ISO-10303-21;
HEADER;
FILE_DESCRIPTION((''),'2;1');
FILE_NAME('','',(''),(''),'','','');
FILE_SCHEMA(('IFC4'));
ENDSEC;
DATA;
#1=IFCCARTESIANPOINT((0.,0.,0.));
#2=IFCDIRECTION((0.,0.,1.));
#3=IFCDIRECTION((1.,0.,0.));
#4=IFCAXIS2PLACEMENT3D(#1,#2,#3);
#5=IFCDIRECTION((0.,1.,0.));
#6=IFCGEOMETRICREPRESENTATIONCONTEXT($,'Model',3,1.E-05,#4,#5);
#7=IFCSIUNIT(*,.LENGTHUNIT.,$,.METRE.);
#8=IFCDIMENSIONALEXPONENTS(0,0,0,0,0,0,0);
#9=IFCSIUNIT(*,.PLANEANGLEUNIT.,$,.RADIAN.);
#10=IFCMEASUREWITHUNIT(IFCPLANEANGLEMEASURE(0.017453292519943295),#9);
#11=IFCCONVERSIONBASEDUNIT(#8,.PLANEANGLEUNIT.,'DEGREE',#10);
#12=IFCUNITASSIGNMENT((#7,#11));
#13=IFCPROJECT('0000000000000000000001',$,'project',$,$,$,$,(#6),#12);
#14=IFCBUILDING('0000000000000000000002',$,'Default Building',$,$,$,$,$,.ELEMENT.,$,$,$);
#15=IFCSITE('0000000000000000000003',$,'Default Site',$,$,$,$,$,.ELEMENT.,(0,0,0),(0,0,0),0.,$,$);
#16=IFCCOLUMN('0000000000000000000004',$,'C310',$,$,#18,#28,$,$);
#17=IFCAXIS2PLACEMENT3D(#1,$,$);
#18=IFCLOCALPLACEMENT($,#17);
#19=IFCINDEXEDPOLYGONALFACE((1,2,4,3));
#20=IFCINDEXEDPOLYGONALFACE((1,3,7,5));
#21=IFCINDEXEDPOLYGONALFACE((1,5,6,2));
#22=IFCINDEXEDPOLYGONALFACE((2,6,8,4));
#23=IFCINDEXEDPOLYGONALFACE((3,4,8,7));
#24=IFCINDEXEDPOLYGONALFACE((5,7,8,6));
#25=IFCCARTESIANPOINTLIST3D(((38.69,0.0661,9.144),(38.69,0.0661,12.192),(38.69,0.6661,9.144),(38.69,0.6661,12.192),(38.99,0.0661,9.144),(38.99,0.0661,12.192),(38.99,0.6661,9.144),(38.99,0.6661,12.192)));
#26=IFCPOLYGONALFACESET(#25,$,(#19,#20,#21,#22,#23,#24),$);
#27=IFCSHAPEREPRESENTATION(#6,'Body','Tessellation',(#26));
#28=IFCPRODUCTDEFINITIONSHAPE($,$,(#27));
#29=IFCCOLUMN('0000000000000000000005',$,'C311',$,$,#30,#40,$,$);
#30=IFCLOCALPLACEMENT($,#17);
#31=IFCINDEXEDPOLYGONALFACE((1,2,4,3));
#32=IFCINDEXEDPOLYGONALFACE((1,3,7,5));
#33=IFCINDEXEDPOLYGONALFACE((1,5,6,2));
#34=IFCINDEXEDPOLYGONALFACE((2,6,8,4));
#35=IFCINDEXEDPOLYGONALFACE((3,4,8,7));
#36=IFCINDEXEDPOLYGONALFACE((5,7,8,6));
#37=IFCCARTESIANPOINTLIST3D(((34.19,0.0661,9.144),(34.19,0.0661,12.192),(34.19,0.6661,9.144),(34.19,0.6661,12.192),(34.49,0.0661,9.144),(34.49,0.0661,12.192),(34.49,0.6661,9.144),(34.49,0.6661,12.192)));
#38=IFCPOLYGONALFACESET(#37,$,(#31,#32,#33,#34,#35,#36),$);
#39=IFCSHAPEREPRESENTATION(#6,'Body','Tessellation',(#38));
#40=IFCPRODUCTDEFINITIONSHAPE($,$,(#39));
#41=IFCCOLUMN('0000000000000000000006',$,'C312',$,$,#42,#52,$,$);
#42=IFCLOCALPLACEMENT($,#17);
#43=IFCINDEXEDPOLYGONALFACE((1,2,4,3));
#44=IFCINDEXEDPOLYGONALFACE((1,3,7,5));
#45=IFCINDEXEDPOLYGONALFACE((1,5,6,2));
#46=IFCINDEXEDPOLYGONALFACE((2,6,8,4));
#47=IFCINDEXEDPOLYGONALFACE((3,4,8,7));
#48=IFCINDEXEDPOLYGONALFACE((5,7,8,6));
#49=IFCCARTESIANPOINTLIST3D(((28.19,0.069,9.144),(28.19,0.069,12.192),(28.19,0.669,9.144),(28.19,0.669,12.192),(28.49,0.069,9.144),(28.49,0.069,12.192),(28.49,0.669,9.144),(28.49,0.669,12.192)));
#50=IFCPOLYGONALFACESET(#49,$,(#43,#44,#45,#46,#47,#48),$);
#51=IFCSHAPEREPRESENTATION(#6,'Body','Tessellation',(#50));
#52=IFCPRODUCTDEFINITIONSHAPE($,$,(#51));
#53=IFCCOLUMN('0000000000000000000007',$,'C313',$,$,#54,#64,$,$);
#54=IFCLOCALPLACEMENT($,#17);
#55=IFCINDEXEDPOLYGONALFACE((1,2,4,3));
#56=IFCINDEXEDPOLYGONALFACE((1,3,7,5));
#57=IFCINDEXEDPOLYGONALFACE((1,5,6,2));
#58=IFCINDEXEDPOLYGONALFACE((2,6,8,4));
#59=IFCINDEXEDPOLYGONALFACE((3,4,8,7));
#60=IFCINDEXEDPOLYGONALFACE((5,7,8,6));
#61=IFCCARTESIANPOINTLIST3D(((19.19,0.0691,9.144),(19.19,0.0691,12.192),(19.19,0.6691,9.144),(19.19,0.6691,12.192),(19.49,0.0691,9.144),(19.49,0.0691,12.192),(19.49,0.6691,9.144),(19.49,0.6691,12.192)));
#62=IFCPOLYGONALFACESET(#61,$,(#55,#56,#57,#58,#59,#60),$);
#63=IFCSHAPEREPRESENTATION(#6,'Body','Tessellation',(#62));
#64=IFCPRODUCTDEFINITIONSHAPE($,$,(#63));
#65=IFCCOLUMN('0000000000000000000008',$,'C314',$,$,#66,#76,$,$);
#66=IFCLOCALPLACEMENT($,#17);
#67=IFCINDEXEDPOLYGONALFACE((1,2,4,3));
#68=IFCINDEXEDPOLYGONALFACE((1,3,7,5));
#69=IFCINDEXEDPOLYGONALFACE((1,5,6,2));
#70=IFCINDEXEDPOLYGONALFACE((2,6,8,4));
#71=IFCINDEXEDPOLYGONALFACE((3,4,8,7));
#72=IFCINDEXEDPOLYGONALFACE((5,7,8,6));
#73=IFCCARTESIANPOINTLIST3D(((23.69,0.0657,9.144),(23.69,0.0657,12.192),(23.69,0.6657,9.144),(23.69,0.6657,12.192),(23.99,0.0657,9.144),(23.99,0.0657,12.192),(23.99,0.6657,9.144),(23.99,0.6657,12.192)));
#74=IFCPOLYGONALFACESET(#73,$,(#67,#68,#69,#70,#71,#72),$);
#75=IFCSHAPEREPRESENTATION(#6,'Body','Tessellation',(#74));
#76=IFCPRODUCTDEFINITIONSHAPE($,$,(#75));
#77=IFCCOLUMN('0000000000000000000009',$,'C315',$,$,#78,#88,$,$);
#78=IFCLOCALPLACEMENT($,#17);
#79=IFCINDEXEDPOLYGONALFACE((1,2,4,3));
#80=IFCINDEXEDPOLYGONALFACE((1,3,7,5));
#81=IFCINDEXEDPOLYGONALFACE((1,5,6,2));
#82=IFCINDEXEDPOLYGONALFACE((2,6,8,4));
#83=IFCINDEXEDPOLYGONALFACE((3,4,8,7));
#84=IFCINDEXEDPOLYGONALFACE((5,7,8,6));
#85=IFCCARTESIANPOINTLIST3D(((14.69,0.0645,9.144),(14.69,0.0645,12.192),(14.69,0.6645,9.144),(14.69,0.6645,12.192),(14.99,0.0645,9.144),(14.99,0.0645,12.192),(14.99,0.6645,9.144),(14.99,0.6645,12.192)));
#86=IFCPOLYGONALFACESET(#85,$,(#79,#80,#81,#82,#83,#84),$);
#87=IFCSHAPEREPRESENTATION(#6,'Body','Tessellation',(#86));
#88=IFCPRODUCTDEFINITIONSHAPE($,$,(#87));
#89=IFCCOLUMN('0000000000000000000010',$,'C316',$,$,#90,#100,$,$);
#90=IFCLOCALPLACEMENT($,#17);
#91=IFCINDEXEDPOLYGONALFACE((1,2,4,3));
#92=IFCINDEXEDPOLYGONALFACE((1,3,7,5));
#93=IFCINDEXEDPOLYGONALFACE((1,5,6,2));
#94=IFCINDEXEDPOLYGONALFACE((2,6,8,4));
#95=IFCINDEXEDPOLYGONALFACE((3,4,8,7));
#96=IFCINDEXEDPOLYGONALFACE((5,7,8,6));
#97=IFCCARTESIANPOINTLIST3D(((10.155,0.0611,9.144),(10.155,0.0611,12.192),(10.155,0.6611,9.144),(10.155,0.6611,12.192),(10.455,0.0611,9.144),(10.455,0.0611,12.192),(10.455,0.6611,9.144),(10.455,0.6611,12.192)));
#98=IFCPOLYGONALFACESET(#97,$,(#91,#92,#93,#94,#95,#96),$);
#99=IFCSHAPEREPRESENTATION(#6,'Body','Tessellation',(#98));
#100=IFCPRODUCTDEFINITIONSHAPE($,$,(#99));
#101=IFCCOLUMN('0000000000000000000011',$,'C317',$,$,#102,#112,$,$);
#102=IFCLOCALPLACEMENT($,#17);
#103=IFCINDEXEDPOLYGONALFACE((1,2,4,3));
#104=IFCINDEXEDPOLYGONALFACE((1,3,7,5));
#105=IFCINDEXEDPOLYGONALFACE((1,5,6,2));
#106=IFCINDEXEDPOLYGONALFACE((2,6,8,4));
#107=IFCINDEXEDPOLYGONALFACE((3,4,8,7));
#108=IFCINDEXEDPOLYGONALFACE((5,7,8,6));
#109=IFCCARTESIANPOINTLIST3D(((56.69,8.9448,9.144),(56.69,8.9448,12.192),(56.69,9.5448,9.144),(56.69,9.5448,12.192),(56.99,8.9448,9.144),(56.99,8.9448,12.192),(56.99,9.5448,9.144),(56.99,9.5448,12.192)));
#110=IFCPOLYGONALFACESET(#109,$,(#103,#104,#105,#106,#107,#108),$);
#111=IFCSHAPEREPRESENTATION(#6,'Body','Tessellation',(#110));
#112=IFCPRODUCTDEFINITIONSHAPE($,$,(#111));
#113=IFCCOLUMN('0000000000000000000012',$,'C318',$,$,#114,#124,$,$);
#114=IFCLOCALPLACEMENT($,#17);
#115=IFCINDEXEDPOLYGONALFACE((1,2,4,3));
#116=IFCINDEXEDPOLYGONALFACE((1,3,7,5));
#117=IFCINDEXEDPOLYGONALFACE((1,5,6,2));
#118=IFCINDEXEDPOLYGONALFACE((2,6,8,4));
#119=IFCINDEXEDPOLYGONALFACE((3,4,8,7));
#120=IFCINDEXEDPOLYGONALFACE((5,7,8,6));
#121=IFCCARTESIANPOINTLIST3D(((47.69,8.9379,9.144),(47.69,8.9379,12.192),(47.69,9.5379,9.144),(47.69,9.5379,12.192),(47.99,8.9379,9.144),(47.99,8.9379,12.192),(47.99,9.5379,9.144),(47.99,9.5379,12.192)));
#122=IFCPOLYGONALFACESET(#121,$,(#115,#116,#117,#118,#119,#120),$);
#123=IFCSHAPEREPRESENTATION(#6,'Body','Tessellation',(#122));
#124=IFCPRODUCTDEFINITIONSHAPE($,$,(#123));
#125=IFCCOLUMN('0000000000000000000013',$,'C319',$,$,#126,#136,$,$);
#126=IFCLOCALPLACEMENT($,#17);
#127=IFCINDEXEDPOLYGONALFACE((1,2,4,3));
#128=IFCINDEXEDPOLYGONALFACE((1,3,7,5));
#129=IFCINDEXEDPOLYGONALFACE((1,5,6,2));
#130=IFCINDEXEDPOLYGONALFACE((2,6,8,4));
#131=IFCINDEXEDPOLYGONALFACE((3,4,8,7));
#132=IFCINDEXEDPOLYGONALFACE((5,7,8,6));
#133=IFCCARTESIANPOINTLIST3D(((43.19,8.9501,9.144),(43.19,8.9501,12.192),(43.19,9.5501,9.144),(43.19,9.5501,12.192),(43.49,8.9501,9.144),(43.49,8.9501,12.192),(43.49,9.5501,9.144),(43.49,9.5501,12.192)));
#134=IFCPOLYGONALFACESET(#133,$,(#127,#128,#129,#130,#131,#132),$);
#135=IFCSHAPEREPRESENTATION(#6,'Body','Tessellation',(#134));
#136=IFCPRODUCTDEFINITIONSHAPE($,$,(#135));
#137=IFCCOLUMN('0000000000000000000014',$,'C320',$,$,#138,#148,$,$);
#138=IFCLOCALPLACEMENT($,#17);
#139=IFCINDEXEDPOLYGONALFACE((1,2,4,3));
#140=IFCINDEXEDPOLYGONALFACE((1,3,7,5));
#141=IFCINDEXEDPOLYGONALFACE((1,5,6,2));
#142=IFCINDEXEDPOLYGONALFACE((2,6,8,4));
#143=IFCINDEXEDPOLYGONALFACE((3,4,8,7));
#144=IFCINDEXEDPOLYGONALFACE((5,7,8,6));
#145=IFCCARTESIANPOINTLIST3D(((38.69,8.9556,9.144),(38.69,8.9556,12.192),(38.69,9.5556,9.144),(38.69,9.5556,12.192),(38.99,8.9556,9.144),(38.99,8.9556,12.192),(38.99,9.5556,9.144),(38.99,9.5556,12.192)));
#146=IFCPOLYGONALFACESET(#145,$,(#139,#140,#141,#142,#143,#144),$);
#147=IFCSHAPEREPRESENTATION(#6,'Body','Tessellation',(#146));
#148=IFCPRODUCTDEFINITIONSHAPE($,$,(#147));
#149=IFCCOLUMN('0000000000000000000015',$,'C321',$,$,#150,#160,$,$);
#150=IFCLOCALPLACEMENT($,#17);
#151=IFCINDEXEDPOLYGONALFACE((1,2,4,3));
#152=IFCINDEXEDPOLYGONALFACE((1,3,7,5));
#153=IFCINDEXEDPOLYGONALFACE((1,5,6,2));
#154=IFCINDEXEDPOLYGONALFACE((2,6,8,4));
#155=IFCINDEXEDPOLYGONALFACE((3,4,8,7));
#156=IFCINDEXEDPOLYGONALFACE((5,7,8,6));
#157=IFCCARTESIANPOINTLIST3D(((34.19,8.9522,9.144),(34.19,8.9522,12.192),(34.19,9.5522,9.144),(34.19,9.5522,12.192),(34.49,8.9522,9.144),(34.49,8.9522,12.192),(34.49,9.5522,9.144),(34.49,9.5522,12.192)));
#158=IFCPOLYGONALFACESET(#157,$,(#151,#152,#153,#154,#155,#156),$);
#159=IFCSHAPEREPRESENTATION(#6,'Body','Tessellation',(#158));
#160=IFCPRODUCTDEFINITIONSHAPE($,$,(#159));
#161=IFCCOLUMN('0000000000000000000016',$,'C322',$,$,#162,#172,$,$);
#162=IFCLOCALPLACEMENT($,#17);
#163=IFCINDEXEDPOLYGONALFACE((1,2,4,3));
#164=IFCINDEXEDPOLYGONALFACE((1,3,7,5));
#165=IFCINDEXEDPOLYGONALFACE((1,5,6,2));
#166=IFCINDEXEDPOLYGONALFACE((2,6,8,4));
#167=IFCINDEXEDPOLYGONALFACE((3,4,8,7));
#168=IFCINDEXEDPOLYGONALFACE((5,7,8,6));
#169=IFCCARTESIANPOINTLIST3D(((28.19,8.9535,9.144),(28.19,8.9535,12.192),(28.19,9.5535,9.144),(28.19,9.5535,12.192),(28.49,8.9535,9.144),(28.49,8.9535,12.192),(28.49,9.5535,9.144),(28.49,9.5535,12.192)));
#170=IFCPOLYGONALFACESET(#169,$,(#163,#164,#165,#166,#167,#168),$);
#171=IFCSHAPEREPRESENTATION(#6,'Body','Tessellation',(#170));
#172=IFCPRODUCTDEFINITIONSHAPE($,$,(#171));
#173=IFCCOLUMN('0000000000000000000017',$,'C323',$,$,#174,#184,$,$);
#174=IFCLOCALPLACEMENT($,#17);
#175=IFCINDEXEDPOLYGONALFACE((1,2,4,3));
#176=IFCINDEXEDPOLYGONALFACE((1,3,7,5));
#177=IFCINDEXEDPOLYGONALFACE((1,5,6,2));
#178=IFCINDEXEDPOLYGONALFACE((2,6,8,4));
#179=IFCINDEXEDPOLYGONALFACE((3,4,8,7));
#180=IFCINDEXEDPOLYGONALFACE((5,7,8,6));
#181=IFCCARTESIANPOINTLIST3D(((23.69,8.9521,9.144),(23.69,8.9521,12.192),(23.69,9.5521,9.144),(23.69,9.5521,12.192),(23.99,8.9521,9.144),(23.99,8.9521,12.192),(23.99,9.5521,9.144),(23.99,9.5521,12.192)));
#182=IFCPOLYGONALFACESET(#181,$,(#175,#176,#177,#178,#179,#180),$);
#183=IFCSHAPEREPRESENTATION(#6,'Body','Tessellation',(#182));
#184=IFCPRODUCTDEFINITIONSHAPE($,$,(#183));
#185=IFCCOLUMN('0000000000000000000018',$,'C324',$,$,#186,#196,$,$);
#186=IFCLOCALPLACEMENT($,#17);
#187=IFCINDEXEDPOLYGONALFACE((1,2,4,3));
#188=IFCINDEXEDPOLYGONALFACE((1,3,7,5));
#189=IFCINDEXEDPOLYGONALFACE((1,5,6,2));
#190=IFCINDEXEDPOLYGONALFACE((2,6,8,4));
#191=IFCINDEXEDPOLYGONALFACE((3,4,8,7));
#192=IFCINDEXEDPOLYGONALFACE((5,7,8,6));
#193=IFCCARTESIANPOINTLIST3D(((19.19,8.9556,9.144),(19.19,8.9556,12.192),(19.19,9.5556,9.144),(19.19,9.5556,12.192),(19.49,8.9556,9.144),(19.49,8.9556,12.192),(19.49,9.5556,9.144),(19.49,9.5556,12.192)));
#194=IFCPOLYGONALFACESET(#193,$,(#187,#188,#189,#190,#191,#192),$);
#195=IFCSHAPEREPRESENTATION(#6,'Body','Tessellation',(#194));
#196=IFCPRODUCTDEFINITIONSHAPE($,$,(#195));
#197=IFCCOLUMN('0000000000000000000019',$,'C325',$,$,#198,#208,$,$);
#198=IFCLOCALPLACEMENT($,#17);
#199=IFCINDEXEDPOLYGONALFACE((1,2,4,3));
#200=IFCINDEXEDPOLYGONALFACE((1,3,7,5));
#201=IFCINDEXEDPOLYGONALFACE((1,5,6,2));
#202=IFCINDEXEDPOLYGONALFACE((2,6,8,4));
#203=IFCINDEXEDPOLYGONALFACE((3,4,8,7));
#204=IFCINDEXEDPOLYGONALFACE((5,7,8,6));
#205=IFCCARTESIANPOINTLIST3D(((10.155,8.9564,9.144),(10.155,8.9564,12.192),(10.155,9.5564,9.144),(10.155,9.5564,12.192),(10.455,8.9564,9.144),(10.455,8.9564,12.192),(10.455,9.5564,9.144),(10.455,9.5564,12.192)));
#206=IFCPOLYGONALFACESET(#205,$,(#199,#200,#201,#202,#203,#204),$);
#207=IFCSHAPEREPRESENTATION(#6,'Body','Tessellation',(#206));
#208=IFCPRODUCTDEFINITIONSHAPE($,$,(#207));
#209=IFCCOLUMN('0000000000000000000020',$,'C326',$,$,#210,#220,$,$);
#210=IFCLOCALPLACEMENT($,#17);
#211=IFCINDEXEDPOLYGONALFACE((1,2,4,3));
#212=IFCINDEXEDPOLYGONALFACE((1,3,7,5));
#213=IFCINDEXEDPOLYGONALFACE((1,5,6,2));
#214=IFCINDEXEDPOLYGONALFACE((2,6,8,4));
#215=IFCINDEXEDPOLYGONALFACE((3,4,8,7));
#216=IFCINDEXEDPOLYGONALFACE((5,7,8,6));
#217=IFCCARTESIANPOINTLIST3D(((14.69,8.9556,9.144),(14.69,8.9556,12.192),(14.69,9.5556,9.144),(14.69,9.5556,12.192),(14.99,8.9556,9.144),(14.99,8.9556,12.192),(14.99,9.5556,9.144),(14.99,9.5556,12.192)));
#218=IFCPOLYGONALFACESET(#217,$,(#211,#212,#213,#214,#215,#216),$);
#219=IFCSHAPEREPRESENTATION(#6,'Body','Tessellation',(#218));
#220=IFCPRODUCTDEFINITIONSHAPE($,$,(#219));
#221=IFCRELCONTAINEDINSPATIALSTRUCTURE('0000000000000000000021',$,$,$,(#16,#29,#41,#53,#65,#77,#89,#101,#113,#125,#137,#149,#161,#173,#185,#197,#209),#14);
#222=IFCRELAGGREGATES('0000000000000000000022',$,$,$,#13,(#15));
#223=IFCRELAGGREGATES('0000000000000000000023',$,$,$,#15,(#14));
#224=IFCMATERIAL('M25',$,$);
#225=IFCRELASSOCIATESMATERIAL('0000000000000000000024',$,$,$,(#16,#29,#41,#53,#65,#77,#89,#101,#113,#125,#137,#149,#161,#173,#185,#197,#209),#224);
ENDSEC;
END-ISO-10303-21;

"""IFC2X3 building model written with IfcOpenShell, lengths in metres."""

from ifc_helpers import new_model, entity, si_unit, converted_unit, direction, frame, frame_2d, origin_with_axes, place, context, project, spatial, rectangle, extrude, material, element, save


model = new_model("IFC2X3")

# Units and contexts
model_context = context("Model", 3, precision=1e-05, world=origin_with_axes(), true_north=direction((0.0, 1.0, 0.0)))
ifc_project = project(units=[si_unit("LENGTHUNIT", "METRE"), converted_unit("PLANEANGLEUNIT", "DEGREE", entity("IfcPlaneAngleMeasure", 0.017453292519943295), si_unit("PLANEANGLEUNIT", "RADIAN"), dimensions=[0, 0, 0, 0, 0, 0, 0])], contexts=[model_context])

# Site, building
site = spatial("IfcSite", under=ifc_project, Name="Default Site", CompositionType="ELEMENT", RefLatitude=(0, 0, 0), RefLongitude=(0, 0, 0), RefElevation=0.0)
building = spatial("IfcBuilding", under=site, Name="Default Building", CompositionType="ELEMENT")

# Columns
ifc_material = material(Name="M25")
placement = place(None, origin_with_axes())
element("IfcColumn", 1, at=placement, inside=building, material=ifc_material, Name="C310", context=model_context, shape_type="SweptSolid", body=[
    extrude(rectangle(XDim=0.3, YDim=0.6, at=frame_2d((0.0, 0.0), x_axis=(1.0, 0.0, 0.0))), frame((38.84, 0.3661, 9.144), z_axis=(0.0, 0.0, 1.0), x_axis=(1.0, 0.0, 0.0)), (0.0, 0.0, 1.0), 3.048),
])
element("IfcColumn", 2, at=placement, inside=building, material=ifc_material, Name="C311", context=model_context, shape_type="SweptSolid", body=[
    extrude(rectangle(XDim=0.3, YDim=0.6, at=frame_2d((0.0, 0.0), x_axis=(1.0, 0.0, 0.0))), frame((34.34, 0.3661, 9.144), z_axis=(0.0, 0.0, 1.0), x_axis=(1.0, 0.0, 0.0)), (0.0, 0.0, 1.0), 3.048),
])
element("IfcColumn", 3, at=placement, inside=building, material=ifc_material, Name="C312", context=model_context, shape_type="SweptSolid", body=[
    extrude(rectangle(XDim=0.3, YDim=0.6, at=frame_2d((0.0, 0.0), x_axis=(1.0, 0.0, 0.0))), frame((28.34, 0.369, 9.144), z_axis=(0.0, 0.0, 1.0), x_axis=(1.0, 0.0, 0.0)), (0.0, 0.0, 1.0), 3.048),
])
element("IfcColumn", 4, at=placement, inside=building, material=ifc_material, Name="C313", context=model_context, shape_type="SweptSolid", body=[
    extrude(rectangle(XDim=0.3, YDim=0.6, at=frame_2d((0.0, 0.0), x_axis=(1.0, 0.0, 0.0))), frame((19.34, 0.3691, 9.144), z_axis=(0.0, 0.0, 1.0), x_axis=(1.0, 0.0, 0.0)), (0.0, 0.0, 1.0), 3.048),
])
element("IfcColumn", 5, at=placement, inside=building, material=ifc_material, Name="C314", context=model_context, shape_type="SweptSolid", body=[
    extrude(rectangle(XDim=0.3, YDim=0.6, at=frame_2d((0.0, 0.0), x_axis=(1.0, 0.0, 0.0))), frame((23.84, 0.3657, 9.144), z_axis=(0.0, 0.0, 1.0), x_axis=(1.0, 0.0, 0.0)), (0.0, 0.0, 1.0), 3.048),
])
element("IfcColumn", 6, at=placement, inside=building, material=ifc_material, Name="C315", context=model_context, shape_type="SweptSolid", body=[
    extrude(rectangle(XDim=0.3, YDim=0.6, at=frame_2d((0.0, 0.0), x_axis=(1.0, 0.0, 0.0))), frame((14.84, 0.3645, 9.144), z_axis=(0.0, 0.0, 1.0), x_axis=(1.0, 0.0, 0.0)), (0.0, 0.0, 1.0), 3.048),
])
element("IfcColumn", 7, at=placement, inside=building, material=ifc_material, Name="C316", context=model_context, shape_type="SweptSolid", body=[
    extrude(rectangle(XDim=0.3, YDim=0.6, at=frame_2d((0.0, 0.0), x_axis=(1.0, 0.0, 0.0))), frame((10.305, 0.3611, 9.144), z_axis=(0.0, 0.0, 1.0), x_axis=(1.0, 0.0, 0.0)), (0.0, 0.0, 1.0), 3.048),
])
element("IfcColumn", 8, at=placement, inside=building, material=ifc_material, Name="C317", context=model_context, shape_type="SweptSolid", body=[
    extrude(rectangle(XDim=0.3, YDim=0.6, at=frame_2d((0.0, 0.0), x_axis=(1.0, 0.0, 0.0))), frame((56.84, 9.2448, 9.144), z_axis=(0.0, 0.0, 1.0), x_axis=(1.0, 0.0, 0.0)), (0.0, 0.0, 1.0), 3.048),
])
element("IfcColumn", 9, at=placement, inside=building, material=ifc_material, Name="C318", context=model_context, shape_type="SweptSolid", body=[
    extrude(rectangle(XDim=0.3, YDim=0.6, at=frame_2d((0.0, 0.0), x_axis=(1.0, 0.0, 0.0))), frame((47.84, 9.2379, 9.144), z_axis=(0.0, 0.0, 1.0), x_axis=(1.0, 0.0, 0.0)), (0.0, 0.0, 1.0), 3.048),
])
element("IfcColumn", 10, at=placement, inside=building, material=ifc_material, Name="C319", context=model_context, shape_type="SweptSolid", body=[
    extrude(rectangle(XDim=0.3, YDim=0.6, at=frame_2d((0.0, 0.0), x_axis=(1.0, 0.0, 0.0))), frame((43.34, 9.2501, 9.144), z_axis=(0.0, 0.0, 1.0), x_axis=(1.0, 0.0, 0.0)), (0.0, 0.0, 1.0), 3.048),
])
element("IfcColumn", 11, at=placement, inside=building, material=ifc_material, Name="C320", context=model_context, shape_type="SweptSolid", body=[
    extrude(rectangle(XDim=0.3, YDim=0.6, at=frame_2d((0.0, 0.0), x_axis=(1.0, 0.0, 0.0))), frame((38.84, 9.2556, 9.144), z_axis=(0.0, 0.0, 1.0), x_axis=(1.0, 0.0, 0.0)), (0.0, 0.0, 1.0), 3.048),
])
element("IfcColumn", 12, at=placement, inside=building, material=ifc_material, Name="C321", context=model_context, shape_type="SweptSolid", body=[
    extrude(rectangle(XDim=0.3, YDim=0.6, at=frame_2d((0.0, 0.0), x_axis=(1.0, 0.0, 0.0))), frame((34.34, 9.2522, 9.144), z_axis=(0.0, 0.0, 1.0), x_axis=(1.0, 0.0, 0.0)), (0.0, 0.0, 1.0), 3.048),
])
element("IfcColumn", 13, at=placement, inside=building, material=ifc_material, Name="C322", context=model_context, shape_type="SweptSolid", body=[
    extrude(rectangle(XDim=0.3, YDim=0.6, at=frame_2d((0.0, 0.0), x_axis=(1.0, 0.0, 0.0))), frame((28.34, 9.2535, 9.144), z_axis=(0.0, 0.0, 1.0), x_axis=(1.0, 0.0, 0.0)), (0.0, 0.0, 1.0), 3.048),
])
element("IfcColumn", 14, at=placement, inside=building, material=ifc_material, Name="C323", context=model_context, shape_type="SweptSolid", body=[
    extrude(rectangle(XDim=0.3, YDim=0.6, at=frame_2d((0.0, 0.0), x_axis=(1.0, 0.0, 0.0))), frame((23.84, 9.2521, 9.144), z_axis=(0.0, 0.0, 1.0), x_axis=(1.0, 0.0, 0.0)), (0.0, 0.0, 1.0), 3.048),
])
element("IfcColumn", 15, at=placement, inside=building, material=ifc_material, Name="C324", context=model_context, shape_type="SweptSolid", body=[
    extrude(rectangle(XDim=0.3, YDim=0.6, at=frame_2d((0.0, 0.0), x_axis=(1.0, 0.0, 0.0))), frame((19.34, 9.2556, 9.144), z_axis=(0.0, 0.0, 1.0), x_axis=(1.0, 0.0, 0.0)), (0.0, 0.0, 1.0), 3.048),
])
element("IfcColumn", 16, at=placement, inside=building, material=ifc_material, Name="C325", context=model_context, shape_type="SweptSolid", body=[
    extrude(rectangle(XDim=0.3, YDim=0.6, at=frame_2d((0.0, 0.0), x_axis=(1.0, 0.0, 0.0))), frame((10.305, 9.2564, 9.144), z_axis=(0.0, 0.0, 1.0), x_axis=(1.0, 0.0, 0.0)), (0.0, 0.0, 1.0), 3.048),
])
element("IfcColumn", 17, at=placement, inside=building, material=ifc_material, Name="C326", context=model_context, shape_type="SweptSolid", body=[
    extrude(rectangle(XDim=0.3, YDim=0.6, at=frame_2d((0.0, 0.0), x_axis=(1.0, 0.0, 0.0))), frame((14.84, 9.2556, 9.144), z_axis=(0.0, 0.0, 1.0), x_axis=(1.0, 0.0, 0.0)), (0.0, 0.0, 1.0), 3.048),
])

save(model, "model.ifc")
